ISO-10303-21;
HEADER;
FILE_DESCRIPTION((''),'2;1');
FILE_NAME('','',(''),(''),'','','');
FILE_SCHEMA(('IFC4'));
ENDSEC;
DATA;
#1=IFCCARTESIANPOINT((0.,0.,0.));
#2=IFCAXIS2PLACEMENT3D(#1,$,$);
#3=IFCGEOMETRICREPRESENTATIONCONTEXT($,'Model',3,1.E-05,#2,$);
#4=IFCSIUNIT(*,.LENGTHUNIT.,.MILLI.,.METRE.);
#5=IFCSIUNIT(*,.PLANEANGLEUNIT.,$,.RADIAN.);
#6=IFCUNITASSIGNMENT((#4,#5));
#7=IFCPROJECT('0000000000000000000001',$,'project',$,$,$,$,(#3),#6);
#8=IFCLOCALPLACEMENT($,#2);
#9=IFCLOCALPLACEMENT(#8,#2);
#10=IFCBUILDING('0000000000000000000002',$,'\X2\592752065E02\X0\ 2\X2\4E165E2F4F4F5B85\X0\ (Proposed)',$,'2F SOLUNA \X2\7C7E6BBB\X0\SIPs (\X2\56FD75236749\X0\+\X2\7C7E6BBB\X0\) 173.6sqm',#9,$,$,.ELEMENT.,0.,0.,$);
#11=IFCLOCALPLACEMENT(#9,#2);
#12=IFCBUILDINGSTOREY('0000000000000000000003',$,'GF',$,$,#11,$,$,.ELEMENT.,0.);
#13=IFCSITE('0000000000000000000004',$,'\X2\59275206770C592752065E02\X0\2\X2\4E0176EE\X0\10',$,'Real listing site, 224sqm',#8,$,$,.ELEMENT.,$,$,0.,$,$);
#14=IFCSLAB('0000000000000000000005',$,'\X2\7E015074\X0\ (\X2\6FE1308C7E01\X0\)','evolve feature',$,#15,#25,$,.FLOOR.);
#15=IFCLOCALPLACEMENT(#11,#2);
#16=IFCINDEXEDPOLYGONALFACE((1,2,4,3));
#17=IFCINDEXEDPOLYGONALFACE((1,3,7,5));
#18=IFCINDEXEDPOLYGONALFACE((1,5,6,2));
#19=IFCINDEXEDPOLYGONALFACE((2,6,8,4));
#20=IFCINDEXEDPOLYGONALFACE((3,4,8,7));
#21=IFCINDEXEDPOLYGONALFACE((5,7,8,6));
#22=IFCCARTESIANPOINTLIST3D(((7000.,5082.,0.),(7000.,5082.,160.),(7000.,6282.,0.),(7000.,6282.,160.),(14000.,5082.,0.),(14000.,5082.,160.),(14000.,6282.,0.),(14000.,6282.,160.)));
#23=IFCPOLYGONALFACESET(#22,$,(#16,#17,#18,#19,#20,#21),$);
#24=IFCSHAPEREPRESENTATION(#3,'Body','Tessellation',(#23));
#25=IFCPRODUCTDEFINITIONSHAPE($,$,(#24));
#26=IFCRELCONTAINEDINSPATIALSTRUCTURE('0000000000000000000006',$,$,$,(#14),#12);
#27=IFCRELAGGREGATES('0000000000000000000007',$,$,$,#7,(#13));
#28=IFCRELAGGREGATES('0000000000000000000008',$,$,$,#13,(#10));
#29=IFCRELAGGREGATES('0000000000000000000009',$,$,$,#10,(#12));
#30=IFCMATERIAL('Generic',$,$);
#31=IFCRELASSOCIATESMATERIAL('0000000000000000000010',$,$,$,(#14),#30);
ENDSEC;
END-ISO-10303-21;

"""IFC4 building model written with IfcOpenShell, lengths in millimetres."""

from ifc_helpers import new_model, si_unit, frame, frame_2d, origin, place, context, project, spatial, rectangle, extrude, material, element, save


model = new_model("IFC4")

# Units and contexts
model_context = context("Model", 3, precision=1e-05, world=origin())
ifc_project = project(units=[si_unit("LENGTHUNIT", "METRE", prefix="MILLI"), si_unit("PLANEANGLEUNIT", "RADIAN")], contexts=[model_context])

# Site, building, storey
site_placement = place(None, origin())
site = spatial("IfcSite", under=ifc_project, at=site_placement, Name="大分県大分市2丁目10", ObjectType="Real listing site, 224sqm", CompositionType="ELEMENT", RefElevation=0.0)
building_placement = place(site_placement, origin())
building = spatial("IfcBuilding", under=site, at=building_placement, Name="大分市 2世帯住宅 (Proposed)", ObjectType="2F SOLUNA 籾殻SIPs (国産杉+籾殻) 173.6sqm", CompositionType="ELEMENT", ElevationOfRefHeight=0.0, ElevationOfTerrain=0.0)
storey_placement = place(building_placement, origin())
storey = spatial("IfcBuildingStorey", under=building, at=storey_placement, Name="GF", CompositionType="ELEMENT", Elevation=0.0)

# Slab
ifc_material_1 = material(Name="Generic")
slab_1_placement = place(storey_placement, frame((3500.0, 2541.0, 0.0)))
element("IfcSlab", 1, at=slab_1_placement, inside=storey, material=ifc_material_1, Name="縁側 (濡れ縁)", Description="evolve feature", PredefinedType="FLOOR", context=model_context, shape_type="SweptSolid", body=[
    extrude(rectangle(XDim=7000.0, YDim=1200.0, at=frame_2d((3500.0, 600.0))), frame((3500.0, 2541.0, 0.0)), (0.0, 0.0, 1.0), 160.0),
])

save(model, "model.ifc")
